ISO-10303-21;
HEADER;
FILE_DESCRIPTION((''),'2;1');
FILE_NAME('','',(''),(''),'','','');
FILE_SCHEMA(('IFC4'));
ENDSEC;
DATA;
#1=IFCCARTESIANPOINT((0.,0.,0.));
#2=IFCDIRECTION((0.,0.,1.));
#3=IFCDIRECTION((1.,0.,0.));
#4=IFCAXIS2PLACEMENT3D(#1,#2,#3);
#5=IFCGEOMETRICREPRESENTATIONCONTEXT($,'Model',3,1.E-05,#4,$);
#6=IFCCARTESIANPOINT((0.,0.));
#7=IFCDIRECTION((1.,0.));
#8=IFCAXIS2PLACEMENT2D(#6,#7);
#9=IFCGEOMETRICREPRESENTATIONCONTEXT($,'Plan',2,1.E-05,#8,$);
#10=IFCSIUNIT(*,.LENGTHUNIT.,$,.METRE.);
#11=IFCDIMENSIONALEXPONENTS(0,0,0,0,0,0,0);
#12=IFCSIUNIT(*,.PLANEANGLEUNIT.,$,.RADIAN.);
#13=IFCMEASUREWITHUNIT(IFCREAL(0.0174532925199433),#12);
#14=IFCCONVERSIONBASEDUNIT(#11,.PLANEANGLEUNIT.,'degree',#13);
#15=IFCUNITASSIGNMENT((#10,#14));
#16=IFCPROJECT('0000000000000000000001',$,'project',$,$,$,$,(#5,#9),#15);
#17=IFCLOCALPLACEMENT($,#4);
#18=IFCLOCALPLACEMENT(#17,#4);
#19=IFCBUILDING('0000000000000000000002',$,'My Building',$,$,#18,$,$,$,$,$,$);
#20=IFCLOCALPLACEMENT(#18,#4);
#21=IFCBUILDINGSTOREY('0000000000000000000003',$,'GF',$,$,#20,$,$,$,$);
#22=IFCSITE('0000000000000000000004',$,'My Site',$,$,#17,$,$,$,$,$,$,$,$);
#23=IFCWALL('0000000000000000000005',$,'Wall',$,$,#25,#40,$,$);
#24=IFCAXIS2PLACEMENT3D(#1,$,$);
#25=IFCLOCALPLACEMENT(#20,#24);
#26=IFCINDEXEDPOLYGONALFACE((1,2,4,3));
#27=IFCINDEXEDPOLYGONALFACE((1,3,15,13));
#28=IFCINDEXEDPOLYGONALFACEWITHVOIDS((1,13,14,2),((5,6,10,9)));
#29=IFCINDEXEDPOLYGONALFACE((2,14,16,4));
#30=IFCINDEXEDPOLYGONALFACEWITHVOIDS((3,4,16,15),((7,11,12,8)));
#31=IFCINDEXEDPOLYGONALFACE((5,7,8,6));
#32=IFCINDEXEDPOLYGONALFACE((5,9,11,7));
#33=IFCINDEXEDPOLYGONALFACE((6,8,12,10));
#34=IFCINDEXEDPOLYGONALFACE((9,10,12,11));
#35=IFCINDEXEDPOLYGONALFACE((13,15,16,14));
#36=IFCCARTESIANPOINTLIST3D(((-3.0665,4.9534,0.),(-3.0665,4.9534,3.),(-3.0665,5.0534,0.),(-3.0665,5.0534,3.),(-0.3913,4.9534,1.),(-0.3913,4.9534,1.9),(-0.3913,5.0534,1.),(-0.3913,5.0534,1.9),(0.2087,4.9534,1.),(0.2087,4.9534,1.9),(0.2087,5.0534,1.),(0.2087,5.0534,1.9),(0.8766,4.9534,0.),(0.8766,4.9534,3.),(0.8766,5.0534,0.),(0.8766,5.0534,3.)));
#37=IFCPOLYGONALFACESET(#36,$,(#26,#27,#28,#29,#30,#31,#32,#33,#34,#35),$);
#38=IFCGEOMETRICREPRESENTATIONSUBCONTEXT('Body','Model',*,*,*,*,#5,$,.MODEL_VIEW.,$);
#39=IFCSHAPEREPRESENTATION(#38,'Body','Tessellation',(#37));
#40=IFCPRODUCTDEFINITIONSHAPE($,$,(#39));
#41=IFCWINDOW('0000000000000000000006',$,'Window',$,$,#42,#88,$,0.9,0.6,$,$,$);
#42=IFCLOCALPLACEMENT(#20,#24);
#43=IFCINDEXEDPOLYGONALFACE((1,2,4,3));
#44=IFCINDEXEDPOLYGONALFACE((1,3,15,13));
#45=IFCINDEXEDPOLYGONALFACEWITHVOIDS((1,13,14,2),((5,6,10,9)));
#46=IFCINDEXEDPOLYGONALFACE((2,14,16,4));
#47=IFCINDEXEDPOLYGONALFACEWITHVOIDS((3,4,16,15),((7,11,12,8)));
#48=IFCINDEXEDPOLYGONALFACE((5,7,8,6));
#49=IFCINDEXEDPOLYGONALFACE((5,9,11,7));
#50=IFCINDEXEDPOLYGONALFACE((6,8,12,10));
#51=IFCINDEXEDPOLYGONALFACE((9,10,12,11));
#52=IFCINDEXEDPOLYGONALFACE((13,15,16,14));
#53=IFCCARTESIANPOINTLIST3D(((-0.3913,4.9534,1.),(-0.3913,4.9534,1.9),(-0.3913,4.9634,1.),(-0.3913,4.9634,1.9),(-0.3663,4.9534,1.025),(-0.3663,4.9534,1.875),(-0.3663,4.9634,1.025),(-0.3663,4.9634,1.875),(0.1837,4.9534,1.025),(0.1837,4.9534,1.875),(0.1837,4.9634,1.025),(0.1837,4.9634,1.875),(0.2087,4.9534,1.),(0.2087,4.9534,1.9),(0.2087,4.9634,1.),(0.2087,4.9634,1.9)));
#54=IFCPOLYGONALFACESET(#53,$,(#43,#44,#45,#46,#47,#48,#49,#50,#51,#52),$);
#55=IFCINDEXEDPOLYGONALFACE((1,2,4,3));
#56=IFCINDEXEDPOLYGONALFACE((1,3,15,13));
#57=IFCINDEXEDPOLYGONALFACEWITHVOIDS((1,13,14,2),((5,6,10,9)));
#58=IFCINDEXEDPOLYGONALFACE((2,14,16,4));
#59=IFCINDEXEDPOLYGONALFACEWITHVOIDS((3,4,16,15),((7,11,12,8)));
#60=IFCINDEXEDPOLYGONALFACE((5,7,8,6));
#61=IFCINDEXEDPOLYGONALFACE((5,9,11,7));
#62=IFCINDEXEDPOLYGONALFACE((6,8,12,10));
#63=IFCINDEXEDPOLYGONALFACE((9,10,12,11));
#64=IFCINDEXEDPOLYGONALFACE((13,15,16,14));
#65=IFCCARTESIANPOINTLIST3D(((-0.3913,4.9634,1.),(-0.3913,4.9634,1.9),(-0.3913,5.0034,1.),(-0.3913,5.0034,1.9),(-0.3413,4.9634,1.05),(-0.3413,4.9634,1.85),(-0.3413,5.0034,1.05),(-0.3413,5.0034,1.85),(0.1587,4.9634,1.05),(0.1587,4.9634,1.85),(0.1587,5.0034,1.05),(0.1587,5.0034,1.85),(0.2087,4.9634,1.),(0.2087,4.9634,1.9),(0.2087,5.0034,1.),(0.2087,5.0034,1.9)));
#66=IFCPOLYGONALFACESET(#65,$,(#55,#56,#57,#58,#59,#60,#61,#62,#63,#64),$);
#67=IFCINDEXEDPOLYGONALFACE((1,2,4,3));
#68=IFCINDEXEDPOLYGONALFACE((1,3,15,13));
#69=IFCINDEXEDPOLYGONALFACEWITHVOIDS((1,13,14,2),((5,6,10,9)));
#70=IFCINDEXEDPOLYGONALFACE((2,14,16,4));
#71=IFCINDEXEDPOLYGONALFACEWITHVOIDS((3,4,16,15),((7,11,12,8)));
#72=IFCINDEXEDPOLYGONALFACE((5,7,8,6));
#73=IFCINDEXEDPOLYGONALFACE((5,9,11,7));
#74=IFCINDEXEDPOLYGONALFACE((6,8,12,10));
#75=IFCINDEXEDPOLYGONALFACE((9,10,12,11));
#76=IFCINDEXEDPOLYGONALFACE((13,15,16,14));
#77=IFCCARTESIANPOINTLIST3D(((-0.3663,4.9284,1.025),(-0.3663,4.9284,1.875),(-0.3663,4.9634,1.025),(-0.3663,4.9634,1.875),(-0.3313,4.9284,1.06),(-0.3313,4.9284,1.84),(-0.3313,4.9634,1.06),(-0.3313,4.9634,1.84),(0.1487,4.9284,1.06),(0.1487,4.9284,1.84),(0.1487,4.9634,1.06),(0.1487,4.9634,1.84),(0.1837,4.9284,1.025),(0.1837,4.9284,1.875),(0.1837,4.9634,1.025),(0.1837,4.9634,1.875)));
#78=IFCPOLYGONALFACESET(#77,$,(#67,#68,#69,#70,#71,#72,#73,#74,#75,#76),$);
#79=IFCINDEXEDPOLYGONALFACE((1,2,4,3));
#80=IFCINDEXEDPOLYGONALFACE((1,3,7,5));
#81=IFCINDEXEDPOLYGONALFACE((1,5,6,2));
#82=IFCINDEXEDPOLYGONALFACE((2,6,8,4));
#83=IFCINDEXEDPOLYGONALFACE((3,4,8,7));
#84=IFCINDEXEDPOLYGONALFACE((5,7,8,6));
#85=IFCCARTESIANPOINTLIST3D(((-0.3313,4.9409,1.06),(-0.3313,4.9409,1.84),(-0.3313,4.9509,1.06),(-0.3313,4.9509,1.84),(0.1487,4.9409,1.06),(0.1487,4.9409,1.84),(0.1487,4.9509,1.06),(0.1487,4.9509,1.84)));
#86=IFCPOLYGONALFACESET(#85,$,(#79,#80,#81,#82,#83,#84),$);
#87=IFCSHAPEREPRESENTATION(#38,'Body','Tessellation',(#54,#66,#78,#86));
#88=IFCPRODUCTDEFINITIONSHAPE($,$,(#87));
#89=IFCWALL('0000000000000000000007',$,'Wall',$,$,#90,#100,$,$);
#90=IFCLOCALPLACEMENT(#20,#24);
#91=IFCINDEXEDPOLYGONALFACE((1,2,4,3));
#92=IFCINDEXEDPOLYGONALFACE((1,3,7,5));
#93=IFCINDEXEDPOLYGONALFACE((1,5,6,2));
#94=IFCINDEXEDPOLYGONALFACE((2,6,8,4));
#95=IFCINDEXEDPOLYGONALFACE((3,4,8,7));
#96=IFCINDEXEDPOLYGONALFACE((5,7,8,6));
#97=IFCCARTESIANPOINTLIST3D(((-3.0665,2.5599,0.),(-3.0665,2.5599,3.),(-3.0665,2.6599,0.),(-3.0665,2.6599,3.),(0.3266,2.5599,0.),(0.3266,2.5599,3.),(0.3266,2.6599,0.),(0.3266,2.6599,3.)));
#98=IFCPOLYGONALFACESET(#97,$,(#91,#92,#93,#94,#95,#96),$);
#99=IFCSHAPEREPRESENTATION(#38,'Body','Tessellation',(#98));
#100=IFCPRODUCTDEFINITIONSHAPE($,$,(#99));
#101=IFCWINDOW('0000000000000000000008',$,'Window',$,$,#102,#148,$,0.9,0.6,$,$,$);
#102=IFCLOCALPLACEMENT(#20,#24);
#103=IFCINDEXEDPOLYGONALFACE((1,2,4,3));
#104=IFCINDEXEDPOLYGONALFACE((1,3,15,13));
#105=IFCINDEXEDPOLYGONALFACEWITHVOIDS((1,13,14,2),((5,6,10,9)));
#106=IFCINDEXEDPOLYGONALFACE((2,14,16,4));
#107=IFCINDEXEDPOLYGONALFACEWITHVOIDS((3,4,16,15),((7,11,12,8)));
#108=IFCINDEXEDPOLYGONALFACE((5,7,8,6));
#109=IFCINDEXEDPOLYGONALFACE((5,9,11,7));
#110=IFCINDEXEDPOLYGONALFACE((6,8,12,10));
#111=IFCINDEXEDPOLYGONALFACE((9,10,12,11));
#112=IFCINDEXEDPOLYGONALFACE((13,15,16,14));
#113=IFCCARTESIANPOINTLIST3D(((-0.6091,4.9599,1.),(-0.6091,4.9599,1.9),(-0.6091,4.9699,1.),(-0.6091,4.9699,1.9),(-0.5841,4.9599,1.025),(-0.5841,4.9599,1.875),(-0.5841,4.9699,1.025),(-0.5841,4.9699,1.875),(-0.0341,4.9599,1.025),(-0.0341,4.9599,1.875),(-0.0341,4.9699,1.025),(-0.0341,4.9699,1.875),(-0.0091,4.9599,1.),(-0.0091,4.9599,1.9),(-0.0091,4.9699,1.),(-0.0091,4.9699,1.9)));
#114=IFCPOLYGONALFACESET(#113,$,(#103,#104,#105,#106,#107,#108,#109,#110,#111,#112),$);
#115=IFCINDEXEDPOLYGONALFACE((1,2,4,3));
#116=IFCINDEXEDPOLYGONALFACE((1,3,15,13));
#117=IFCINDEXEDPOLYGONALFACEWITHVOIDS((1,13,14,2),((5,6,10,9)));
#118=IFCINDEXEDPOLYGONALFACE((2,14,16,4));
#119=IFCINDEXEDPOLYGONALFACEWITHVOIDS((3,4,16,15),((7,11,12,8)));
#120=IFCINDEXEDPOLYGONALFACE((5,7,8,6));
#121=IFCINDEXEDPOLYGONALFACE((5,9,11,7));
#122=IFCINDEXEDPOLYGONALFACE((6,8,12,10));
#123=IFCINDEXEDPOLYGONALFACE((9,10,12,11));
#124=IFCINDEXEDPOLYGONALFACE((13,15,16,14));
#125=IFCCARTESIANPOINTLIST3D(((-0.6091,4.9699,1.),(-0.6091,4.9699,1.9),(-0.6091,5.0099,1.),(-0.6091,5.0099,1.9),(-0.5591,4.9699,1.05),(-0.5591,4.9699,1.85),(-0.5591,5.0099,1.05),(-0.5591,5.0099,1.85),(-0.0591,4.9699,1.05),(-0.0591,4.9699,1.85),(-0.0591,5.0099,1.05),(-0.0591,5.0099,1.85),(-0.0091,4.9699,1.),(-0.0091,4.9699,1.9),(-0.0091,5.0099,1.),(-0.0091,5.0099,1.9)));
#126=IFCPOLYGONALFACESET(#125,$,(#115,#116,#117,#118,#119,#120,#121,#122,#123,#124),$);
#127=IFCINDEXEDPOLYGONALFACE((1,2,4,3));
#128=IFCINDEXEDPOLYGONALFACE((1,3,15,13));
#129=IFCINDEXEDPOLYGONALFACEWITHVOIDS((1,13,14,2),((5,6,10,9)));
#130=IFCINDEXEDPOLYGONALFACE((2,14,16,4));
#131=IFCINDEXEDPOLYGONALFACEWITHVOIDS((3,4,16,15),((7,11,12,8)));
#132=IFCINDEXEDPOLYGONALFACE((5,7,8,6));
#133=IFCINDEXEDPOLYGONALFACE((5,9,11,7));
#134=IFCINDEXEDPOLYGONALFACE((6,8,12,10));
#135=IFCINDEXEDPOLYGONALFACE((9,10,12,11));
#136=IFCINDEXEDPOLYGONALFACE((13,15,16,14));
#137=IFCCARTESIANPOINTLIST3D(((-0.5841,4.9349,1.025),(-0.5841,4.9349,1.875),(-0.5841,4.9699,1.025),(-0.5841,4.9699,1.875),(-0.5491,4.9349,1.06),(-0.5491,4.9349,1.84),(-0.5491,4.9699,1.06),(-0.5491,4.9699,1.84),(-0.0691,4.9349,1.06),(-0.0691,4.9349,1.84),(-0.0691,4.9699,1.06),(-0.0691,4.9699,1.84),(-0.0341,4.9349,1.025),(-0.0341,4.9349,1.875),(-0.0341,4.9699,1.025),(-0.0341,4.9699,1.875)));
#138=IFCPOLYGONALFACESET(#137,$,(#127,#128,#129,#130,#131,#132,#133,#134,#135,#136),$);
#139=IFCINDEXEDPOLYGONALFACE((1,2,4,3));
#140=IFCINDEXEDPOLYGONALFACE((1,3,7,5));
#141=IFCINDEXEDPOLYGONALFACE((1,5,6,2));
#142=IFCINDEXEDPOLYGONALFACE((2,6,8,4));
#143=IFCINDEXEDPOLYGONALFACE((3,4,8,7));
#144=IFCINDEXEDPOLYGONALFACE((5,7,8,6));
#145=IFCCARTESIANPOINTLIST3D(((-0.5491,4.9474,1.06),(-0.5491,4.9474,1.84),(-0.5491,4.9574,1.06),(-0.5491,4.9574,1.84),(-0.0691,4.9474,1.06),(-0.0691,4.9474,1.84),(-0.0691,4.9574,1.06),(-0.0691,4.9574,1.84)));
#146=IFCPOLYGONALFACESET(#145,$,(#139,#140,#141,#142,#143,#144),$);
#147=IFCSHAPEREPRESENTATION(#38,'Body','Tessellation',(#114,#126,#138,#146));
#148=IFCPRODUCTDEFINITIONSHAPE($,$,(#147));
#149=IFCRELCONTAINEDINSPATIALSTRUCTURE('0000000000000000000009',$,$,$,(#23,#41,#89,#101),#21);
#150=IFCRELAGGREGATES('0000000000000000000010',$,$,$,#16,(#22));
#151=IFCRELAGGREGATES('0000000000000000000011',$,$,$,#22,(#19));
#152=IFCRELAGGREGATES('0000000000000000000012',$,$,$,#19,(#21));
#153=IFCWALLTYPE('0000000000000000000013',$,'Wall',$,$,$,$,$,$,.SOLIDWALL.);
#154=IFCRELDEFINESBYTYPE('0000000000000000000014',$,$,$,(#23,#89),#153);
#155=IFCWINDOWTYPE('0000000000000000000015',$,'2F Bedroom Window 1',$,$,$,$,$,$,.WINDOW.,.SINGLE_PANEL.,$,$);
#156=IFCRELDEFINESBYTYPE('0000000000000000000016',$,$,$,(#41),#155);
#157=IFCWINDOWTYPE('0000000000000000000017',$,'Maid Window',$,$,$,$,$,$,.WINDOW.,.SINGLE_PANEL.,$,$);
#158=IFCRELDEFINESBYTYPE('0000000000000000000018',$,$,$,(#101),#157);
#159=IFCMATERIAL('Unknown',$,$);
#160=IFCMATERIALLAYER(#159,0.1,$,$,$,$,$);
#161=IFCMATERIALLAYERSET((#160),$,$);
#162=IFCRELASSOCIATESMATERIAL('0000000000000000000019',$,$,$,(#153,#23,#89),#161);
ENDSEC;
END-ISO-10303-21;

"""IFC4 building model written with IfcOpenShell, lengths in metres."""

from ifc_helpers import new_model, entity, si_unit, converted_unit, frame, origin_with_axes, origin_2d_with_axis, place, context, subcontext, project, spatial, line, indexed_curve, outline, extrude, shape, source, transform, mapped, material, layer, layer_set, layer_usage, type_object, type_shapes, element, fill, save


model = new_model("IFC4")

# Units and contexts
model_context = context("Model", 3, precision=1e-05, world=origin_with_axes())
plan_context = context("Plan", 2, precision=1e-05, world=origin_2d_with_axis())
body_context_1 = subcontext(model_context, "Body", "Model", "MODEL_VIEW")
body_context_2 = subcontext(plan_context, "Body", "Plan", "PLAN_VIEW")
ifc_project = project(units=[si_unit("LENGTHUNIT", "METRE"), converted_unit("PLANEANGLEUNIT", "degree", entity("IfcReal", 0.0174532925199433), si_unit("PLANEANGLEUNIT", "RADIAN"), dimensions=[0, 0, 0, 0, 0, 0, 0])], contexts=[model_context, plan_context])

# Site, building, storey
site_placement = place(None, origin_with_axes())
site = spatial("IfcSite", under=ifc_project, at=site_placement, Name="My Site")
building_placement = place(site_placement, origin_with_axes())
building = spatial("IfcBuilding", under=site, at=building_placement, Name="My Building")
storey_placement = place(building_placement, origin_with_axes())
storey = spatial("IfcBuildingStorey", under=building, at=storey_placement, Name="GF")

# Shared definitions
ifc_material = material(Name="Unknown")

# Shared definitions
ifc_layer = layer(ifc_material, 0.1)
ifc_layer_set = layer_set([ifc_layer])
wall_type = type_object("IfcWallType", Name="Wall", PredefinedType="SOLIDWALL", material=ifc_layer_set)

# Wall, opening, window
ifc_layer_usage_1 = layer_usage(ifc_layer_set, "AXIS2", "POSITIVE", 0.0)
wall_1_placement = place(storey_placement, frame((0.8766, 5.0534, 0.0), z_axis=(0.0, 0.0, 1.0), x_axis=(-1.0, 0.0, 0.0)))
wall_1 = element("IfcWall", 1, at=wall_1_placement, inside=storey, type_object=wall_type, material=ifc_layer_usage_1, Name="Wall", context=body_context_1, shape_type="SweptSolid", body=[
    extrude(outline(indexed_curve([(0.0, 0.0), (0.0, 0.1), (3.9431, 0.1), (3.9431, 0.0)], segments=[line(1, 2, 3, 4, 1)])), origin_with_axes(), (0.0, 0.0, 1.0), 3.0),
])
shared_shape_1 = source(origin_with_axes(), body_context_1, "Body", "SweptSolid", [
    extrude(outline(indexed_curve([(0.0, 0.0), (0.6, 0.0), (0.6, 0.9), (0.0, 0.9)], segments=[line(1, 2, 3, 4, 1)])), frame((0.0, -0.6, 0.0), z_axis=(0.0, -1.0, 0.0), x_axis=(1.0, 0.0, 0.0)), (0.0, 0.0, -1.0), 1.2),
])
opening_1_placement = place(wall_1_placement, frame((0.6679, 0.0, 1.0), z_axis=(0.0, 0.0, 1.0), x_axis=(1.0, 0.0, 0.0)))
opening_1 = element("IfcOpeningElement", 2, at=opening_1_placement, cuts=wall_1, PredefinedType="OPENING", context=body_context_1, shape_type="MappedRepresentation", body=[
    mapped(shared_shape_1, transform((0.0, 0.0, 0.0), x_axis=(1.0, 0.0, 0.0), y_axis=(0.0, 1.0, 0.0), z_axis=(0.0, 0.0, 1.0), scale=1.0)),
])
window_type_1 = type_object("IfcWindowType", Name="2F Bedroom Window 1", PartitioningType="SINGLE_PANEL", PredefinedType="WINDOW")
shared_shape_2 = source(origin_with_axes(), body_context_1, "Body", "SweptSolid", [
    extrude(outline(indexed_curve([(0.0, 0.0), (0.6, 0.0), (0.6, 0.9), (0.0, 0.9)], segments=[line(1, 2, 3, 4, 1)]), holes=[indexed_curve([(0.025, 0.025), (0.575, 0.025), (0.575, 0.875), (0.025, 0.875)], segments=[line(1, 2, 3, 4, 1)])]), frame((0.0, 0.09, 0.0), z_axis=(0.0, -1.0, 0.0), x_axis=(1.0, 0.0, 0.0)), (0.0, 0.0, -1.0), 0.01),
    extrude(outline(indexed_curve([(0.0, 0.0), (0.6, 0.0), (0.6, 0.9), (0.0, 0.9)], segments=[line(1, 2, 3, 4, 1)]), holes=[indexed_curve([(0.05, 0.05), (0.55, 0.05), (0.55, 0.85), (0.05, 0.85)], segments=[line(1, 2, 3, 4, 1)])]), frame((0.0, 0.05, 0.0), z_axis=(0.0, -1.0, 0.0), x_axis=(1.0, 0.0, 0.0)), (0.0, 0.0, -1.0), 0.04),
    extrude(outline(indexed_curve([(0.0, 0.0), (0.55, 0.0), (0.55, 0.85), (0.0, 0.85)], segments=[line(1, 2, 3, 4, 1)]), holes=[indexed_curve([(0.035, 0.035), (0.515, 0.035), (0.515, 0.815), (0.035, 0.815)], segments=[line(1, 2, 3, 4, 1)])]), frame((0.025, 0.09, 0.025), z_axis=(0.0, -1.0, 0.0), x_axis=(1.0, 0.0, 0.0)), (0.0, 0.0, -1.0), 0.035),
    extrude(outline(indexed_curve([(0.035, 0.035), (0.515, 0.035), (0.515, 0.815), (0.035, 0.815)], segments=[line(1, 2, 3, 4, 1)])), frame((0.025, 0.1025, 0.025), z_axis=(0.0, -1.0, 0.0), x_axis=(1.0, 0.0, 0.0)), (0.0, 0.0, -1.0), 0.01),
])
shared_shape_3 = source(origin_with_axes(), body_context_2, "Body", "Curve2D", [
    entity("IfcIndexedPolyCurve", entity("IfcCartesianPointList2D", [[0.05, 0.05], [0.55, 0.05]])),
    entity("IfcIndexedPolyCurve", entity("IfcCartesianPointList2D", [[0.0, 0.1], [0.025, 0.1], [0.025, 0.09], [0.05, 0.09], [0.05, 0.05], [0.0, 0.05]]), [entity("IfcLineIndex", [1, 2, 3, 4, 5, 6, 1])]),
    entity("IfcIndexedPolyCurve", entity("IfcCartesianPointList2D", [[0.6, 0.1], [0.575, 0.1], [0.575, 0.09], [0.55, 0.09], [0.55, 0.05], [0.6, 0.05]]), [entity("IfcLineIndex", [1, 2, 3, 4, 5, 6, 1])]),
    entity("IfcIndexedPolyCurve", entity("IfcCartesianPointList2D", [[0.025, 0.09], [0.06, 0.09], [0.06, 0.125], [0.025, 0.125]]), [entity("IfcLineIndex", [1, 2, 3, 4, 1])]),
    entity("IfcIndexedPolyCurve", entity("IfcCartesianPointList2D", [[0.575, 0.09], [0.54, 0.09], [0.54, 0.125], [0.575, 0.125]]), [entity("IfcLineIndex", [1, 2, 3, 4, 1])]),
    entity("IfcIndexedPolyCurve", entity("IfcCartesianPointList2D", [[0.06, 0.09], [0.54, 0.09]])),
    entity("IfcIndexedPolyCurve", entity("IfcCartesianPointList2D", [[0.06, 0.125], [0.54, 0.125]])),
    entity("IfcIndexedPolyCurve", entity("IfcCartesianPointList2D", [[0.06, 0.1075], [0.54, 0.1075]])),
])
type_shapes(window_type_1, [shared_shape_2, shared_shape_3])
window_1_placement = place(opening_1_placement, frame((0.0, 0.0, 0.0), z_axis=(0.0, 0.0, 1.0), x_axis=(1.0, 0.0, 0.0)))
window_1 = element("IfcWindow", 3, at=window_1_placement, inside=storey, type_object=window_type_1, Name="Window", OverallHeight=0.9, OverallWidth=0.6, shapes=[
    shape(body_context_1, "Body", "MappedRepresentation", [mapped(shared_shape_2, transform((0.0, 0.0, 0.0), x_axis=(1.0, 0.0, 0.0), y_axis=(0.0, 1.0, 0.0), z_axis=(0.0, 0.0, 1.0), scale=1.0))]),
    shape(body_context_2, "Body", "MappedRepresentation", [mapped(shared_shape_3, transform((0.0, 0.0, 0.0), x_axis=(1.0, 0.0, 0.0), y_axis=(0.0, 1.0, 0.0), z_axis=(0.0, 0.0, 1.0), scale=1.0))]),
])
fill(opening_1, window_1)

# Wall
ifc_layer_usage_2 = layer_usage(ifc_layer_set, "AXIS2", "POSITIVE", 0.0)
wall_2_placement = place(storey_placement, frame((0.3266, 2.6599, 0.0), z_axis=(0.0, 0.0, 1.0), x_axis=(-1.0, 0.0, 0.0)))
element("IfcWall", 4, at=wall_2_placement, inside=storey, type_object=wall_type, material=ifc_layer_usage_2, Name="Wall", context=body_context_1, shape_type="SweptSolid", body=[
    extrude(outline(indexed_curve([(0.0, 0.0), (0.0, 0.1), (3.3931, 0.1), (3.3931, 0.0)], segments=[line(1, 2, 3, 4, 1)])), origin_with_axes(), (0.0, 0.0, 1.0), 3.0),
])

# Window
window_type_2 = type_object("IfcWindowType", Name="Maid Window", PartitioningType="SINGLE_PANEL", PredefinedType="WINDOW")
shared_shape_4 = source(origin_with_axes(), body_context_1, "Body", "SweptSolid", [
    extrude(outline(indexed_curve([(0.0, 0.0), (0.6, 0.0), (0.6, 0.9), (0.0, 0.9)], segments=[line(1, 2, 3, 4, 1)]), holes=[indexed_curve([(0.025, 0.025), (0.575, 0.025), (0.575, 0.875), (0.025, 0.875)], segments=[line(1, 2, 3, 4, 1)])]), frame((0.0, 0.09, 0.0), z_axis=(0.0, -1.0, 0.0), x_axis=(1.0, 0.0, 0.0)), (0.0, 0.0, -1.0), 0.01),
    extrude(outline(indexed_curve([(0.0, 0.0), (0.6, 0.0), (0.6, 0.9), (0.0, 0.9)], segments=[line(1, 2, 3, 4, 1)]), holes=[indexed_curve([(0.05, 0.05), (0.55, 0.05), (0.55, 0.85), (0.05, 0.85)], segments=[line(1, 2, 3, 4, 1)])]), frame((0.0, 0.05, 0.0), z_axis=(0.0, -1.0, 0.0), x_axis=(1.0, 0.0, 0.0)), (0.0, 0.0, -1.0), 0.04),
    extrude(outline(indexed_curve([(0.0, 0.0), (0.55, 0.0), (0.55, 0.85), (0.0, 0.85)], segments=[line(1, 2, 3, 4, 1)]), holes=[indexed_curve([(0.035, 0.035), (0.515, 0.035), (0.515, 0.815), (0.035, 0.815)], segments=[line(1, 2, 3, 4, 1)])]), frame((0.025, 0.09, 0.025), z_axis=(0.0, -1.0, 0.0), x_axis=(1.0, 0.0, 0.0)), (0.0, 0.0, -1.0), 0.035),
    extrude(outline(indexed_curve([(0.035, 0.035), (0.515, 0.035), (0.515, 0.815), (0.035, 0.815)], segments=[line(1, 2, 3, 4, 1)])), frame((0.025, 0.1025, 0.025), z_axis=(0.0, -1.0, 0.0), x_axis=(1.0, 0.0, 0.0)), (0.0, 0.0, -1.0), 0.01),
])
shared_shape_5 = source(origin_with_axes(), body_context_2, "Body", "Curve2D", [
    entity("IfcIndexedPolyCurve", entity("IfcCartesianPointList2D", [[0.05, 0.05], [0.55, 0.05]])),
    entity("IfcIndexedPolyCurve", entity("IfcCartesianPointList2D", [[0.0, 0.1], [0.025, 0.1], [0.025, 0.09], [0.05, 0.09], [0.05, 0.05], [0.0, 0.05]]), [entity("IfcLineIndex", [1, 2, 3, 4, 5, 6, 1])]),
    entity("IfcIndexedPolyCurve", entity("IfcCartesianPointList2D", [[0.6, 0.1], [0.575, 0.1], [0.575, 0.09], [0.55, 0.09], [0.55, 0.05], [0.6, 0.05]]), [entity("IfcLineIndex", [1, 2, 3, 4, 5, 6, 1])]),
    entity("IfcIndexedPolyCurve", entity("IfcCartesianPointList2D", [[0.025, 0.09], [0.06, 0.09], [0.06, 0.125], [0.025, 0.125]]), [entity("IfcLineIndex", [1, 2, 3, 4, 1])]),
    entity("IfcIndexedPolyCurve", entity("IfcCartesianPointList2D", [[0.575, 0.09], [0.54, 0.09], [0.54, 0.125], [0.575, 0.125]]), [entity("IfcLineIndex", [1, 2, 3, 4, 1])]),
    entity("IfcIndexedPolyCurve", entity("IfcCartesianPointList2D", [[0.06, 0.09], [0.54, 0.09]])),
    entity("IfcIndexedPolyCurve", entity("IfcCartesianPointList2D", [[0.06, 0.125], [0.54, 0.125]])),
    entity("IfcIndexedPolyCurve", entity("IfcCartesianPointList2D", [[0.06, 0.1075], [0.54, 0.1075]])),
])
type_shapes(window_type_2, [shared_shape_4, shared_shape_5])
placement_1 = place(storey_placement, frame((0.7766, 5.0599, 0.0), z_axis=(0.0, 0.0, 1.0), x_axis=(-1.0, 0.0, 0.0)))
placement_2 = place(placement_1, frame((0.7857, 0.0, 1.0), z_axis=(0.0, 0.0, 1.0), x_axis=(1.0, 0.0, 0.0)))
window_2_placement = place(placement_2, frame((0.0, 0.0, 0.0), z_axis=(0.0, 0.0, 1.0), x_axis=(1.0, 0.0, 0.0)))
element("IfcWindow", 5, at=window_2_placement, inside=storey, type_object=window_type_2, Name="Window", OverallHeight=0.9, OverallWidth=0.6, shapes=[
    shape(body_context_1, "Body", "MappedRepresentation", [mapped(shared_shape_4, transform((0.0, 0.0, 0.0), x_axis=(1.0, 0.0, 0.0), y_axis=(0.0, 1.0, 0.0), z_axis=(0.0, 0.0, 1.0), scale=1.0))]),
    shape(body_context_2, "Body", "MappedRepresentation", [mapped(shared_shape_5, transform((0.0, 0.0, 0.0), x_axis=(1.0, 0.0, 0.0), y_axis=(0.0, 1.0, 0.0), z_axis=(0.0, 0.0, 1.0), scale=1.0))]),
])

save(model, "model.ifc")
